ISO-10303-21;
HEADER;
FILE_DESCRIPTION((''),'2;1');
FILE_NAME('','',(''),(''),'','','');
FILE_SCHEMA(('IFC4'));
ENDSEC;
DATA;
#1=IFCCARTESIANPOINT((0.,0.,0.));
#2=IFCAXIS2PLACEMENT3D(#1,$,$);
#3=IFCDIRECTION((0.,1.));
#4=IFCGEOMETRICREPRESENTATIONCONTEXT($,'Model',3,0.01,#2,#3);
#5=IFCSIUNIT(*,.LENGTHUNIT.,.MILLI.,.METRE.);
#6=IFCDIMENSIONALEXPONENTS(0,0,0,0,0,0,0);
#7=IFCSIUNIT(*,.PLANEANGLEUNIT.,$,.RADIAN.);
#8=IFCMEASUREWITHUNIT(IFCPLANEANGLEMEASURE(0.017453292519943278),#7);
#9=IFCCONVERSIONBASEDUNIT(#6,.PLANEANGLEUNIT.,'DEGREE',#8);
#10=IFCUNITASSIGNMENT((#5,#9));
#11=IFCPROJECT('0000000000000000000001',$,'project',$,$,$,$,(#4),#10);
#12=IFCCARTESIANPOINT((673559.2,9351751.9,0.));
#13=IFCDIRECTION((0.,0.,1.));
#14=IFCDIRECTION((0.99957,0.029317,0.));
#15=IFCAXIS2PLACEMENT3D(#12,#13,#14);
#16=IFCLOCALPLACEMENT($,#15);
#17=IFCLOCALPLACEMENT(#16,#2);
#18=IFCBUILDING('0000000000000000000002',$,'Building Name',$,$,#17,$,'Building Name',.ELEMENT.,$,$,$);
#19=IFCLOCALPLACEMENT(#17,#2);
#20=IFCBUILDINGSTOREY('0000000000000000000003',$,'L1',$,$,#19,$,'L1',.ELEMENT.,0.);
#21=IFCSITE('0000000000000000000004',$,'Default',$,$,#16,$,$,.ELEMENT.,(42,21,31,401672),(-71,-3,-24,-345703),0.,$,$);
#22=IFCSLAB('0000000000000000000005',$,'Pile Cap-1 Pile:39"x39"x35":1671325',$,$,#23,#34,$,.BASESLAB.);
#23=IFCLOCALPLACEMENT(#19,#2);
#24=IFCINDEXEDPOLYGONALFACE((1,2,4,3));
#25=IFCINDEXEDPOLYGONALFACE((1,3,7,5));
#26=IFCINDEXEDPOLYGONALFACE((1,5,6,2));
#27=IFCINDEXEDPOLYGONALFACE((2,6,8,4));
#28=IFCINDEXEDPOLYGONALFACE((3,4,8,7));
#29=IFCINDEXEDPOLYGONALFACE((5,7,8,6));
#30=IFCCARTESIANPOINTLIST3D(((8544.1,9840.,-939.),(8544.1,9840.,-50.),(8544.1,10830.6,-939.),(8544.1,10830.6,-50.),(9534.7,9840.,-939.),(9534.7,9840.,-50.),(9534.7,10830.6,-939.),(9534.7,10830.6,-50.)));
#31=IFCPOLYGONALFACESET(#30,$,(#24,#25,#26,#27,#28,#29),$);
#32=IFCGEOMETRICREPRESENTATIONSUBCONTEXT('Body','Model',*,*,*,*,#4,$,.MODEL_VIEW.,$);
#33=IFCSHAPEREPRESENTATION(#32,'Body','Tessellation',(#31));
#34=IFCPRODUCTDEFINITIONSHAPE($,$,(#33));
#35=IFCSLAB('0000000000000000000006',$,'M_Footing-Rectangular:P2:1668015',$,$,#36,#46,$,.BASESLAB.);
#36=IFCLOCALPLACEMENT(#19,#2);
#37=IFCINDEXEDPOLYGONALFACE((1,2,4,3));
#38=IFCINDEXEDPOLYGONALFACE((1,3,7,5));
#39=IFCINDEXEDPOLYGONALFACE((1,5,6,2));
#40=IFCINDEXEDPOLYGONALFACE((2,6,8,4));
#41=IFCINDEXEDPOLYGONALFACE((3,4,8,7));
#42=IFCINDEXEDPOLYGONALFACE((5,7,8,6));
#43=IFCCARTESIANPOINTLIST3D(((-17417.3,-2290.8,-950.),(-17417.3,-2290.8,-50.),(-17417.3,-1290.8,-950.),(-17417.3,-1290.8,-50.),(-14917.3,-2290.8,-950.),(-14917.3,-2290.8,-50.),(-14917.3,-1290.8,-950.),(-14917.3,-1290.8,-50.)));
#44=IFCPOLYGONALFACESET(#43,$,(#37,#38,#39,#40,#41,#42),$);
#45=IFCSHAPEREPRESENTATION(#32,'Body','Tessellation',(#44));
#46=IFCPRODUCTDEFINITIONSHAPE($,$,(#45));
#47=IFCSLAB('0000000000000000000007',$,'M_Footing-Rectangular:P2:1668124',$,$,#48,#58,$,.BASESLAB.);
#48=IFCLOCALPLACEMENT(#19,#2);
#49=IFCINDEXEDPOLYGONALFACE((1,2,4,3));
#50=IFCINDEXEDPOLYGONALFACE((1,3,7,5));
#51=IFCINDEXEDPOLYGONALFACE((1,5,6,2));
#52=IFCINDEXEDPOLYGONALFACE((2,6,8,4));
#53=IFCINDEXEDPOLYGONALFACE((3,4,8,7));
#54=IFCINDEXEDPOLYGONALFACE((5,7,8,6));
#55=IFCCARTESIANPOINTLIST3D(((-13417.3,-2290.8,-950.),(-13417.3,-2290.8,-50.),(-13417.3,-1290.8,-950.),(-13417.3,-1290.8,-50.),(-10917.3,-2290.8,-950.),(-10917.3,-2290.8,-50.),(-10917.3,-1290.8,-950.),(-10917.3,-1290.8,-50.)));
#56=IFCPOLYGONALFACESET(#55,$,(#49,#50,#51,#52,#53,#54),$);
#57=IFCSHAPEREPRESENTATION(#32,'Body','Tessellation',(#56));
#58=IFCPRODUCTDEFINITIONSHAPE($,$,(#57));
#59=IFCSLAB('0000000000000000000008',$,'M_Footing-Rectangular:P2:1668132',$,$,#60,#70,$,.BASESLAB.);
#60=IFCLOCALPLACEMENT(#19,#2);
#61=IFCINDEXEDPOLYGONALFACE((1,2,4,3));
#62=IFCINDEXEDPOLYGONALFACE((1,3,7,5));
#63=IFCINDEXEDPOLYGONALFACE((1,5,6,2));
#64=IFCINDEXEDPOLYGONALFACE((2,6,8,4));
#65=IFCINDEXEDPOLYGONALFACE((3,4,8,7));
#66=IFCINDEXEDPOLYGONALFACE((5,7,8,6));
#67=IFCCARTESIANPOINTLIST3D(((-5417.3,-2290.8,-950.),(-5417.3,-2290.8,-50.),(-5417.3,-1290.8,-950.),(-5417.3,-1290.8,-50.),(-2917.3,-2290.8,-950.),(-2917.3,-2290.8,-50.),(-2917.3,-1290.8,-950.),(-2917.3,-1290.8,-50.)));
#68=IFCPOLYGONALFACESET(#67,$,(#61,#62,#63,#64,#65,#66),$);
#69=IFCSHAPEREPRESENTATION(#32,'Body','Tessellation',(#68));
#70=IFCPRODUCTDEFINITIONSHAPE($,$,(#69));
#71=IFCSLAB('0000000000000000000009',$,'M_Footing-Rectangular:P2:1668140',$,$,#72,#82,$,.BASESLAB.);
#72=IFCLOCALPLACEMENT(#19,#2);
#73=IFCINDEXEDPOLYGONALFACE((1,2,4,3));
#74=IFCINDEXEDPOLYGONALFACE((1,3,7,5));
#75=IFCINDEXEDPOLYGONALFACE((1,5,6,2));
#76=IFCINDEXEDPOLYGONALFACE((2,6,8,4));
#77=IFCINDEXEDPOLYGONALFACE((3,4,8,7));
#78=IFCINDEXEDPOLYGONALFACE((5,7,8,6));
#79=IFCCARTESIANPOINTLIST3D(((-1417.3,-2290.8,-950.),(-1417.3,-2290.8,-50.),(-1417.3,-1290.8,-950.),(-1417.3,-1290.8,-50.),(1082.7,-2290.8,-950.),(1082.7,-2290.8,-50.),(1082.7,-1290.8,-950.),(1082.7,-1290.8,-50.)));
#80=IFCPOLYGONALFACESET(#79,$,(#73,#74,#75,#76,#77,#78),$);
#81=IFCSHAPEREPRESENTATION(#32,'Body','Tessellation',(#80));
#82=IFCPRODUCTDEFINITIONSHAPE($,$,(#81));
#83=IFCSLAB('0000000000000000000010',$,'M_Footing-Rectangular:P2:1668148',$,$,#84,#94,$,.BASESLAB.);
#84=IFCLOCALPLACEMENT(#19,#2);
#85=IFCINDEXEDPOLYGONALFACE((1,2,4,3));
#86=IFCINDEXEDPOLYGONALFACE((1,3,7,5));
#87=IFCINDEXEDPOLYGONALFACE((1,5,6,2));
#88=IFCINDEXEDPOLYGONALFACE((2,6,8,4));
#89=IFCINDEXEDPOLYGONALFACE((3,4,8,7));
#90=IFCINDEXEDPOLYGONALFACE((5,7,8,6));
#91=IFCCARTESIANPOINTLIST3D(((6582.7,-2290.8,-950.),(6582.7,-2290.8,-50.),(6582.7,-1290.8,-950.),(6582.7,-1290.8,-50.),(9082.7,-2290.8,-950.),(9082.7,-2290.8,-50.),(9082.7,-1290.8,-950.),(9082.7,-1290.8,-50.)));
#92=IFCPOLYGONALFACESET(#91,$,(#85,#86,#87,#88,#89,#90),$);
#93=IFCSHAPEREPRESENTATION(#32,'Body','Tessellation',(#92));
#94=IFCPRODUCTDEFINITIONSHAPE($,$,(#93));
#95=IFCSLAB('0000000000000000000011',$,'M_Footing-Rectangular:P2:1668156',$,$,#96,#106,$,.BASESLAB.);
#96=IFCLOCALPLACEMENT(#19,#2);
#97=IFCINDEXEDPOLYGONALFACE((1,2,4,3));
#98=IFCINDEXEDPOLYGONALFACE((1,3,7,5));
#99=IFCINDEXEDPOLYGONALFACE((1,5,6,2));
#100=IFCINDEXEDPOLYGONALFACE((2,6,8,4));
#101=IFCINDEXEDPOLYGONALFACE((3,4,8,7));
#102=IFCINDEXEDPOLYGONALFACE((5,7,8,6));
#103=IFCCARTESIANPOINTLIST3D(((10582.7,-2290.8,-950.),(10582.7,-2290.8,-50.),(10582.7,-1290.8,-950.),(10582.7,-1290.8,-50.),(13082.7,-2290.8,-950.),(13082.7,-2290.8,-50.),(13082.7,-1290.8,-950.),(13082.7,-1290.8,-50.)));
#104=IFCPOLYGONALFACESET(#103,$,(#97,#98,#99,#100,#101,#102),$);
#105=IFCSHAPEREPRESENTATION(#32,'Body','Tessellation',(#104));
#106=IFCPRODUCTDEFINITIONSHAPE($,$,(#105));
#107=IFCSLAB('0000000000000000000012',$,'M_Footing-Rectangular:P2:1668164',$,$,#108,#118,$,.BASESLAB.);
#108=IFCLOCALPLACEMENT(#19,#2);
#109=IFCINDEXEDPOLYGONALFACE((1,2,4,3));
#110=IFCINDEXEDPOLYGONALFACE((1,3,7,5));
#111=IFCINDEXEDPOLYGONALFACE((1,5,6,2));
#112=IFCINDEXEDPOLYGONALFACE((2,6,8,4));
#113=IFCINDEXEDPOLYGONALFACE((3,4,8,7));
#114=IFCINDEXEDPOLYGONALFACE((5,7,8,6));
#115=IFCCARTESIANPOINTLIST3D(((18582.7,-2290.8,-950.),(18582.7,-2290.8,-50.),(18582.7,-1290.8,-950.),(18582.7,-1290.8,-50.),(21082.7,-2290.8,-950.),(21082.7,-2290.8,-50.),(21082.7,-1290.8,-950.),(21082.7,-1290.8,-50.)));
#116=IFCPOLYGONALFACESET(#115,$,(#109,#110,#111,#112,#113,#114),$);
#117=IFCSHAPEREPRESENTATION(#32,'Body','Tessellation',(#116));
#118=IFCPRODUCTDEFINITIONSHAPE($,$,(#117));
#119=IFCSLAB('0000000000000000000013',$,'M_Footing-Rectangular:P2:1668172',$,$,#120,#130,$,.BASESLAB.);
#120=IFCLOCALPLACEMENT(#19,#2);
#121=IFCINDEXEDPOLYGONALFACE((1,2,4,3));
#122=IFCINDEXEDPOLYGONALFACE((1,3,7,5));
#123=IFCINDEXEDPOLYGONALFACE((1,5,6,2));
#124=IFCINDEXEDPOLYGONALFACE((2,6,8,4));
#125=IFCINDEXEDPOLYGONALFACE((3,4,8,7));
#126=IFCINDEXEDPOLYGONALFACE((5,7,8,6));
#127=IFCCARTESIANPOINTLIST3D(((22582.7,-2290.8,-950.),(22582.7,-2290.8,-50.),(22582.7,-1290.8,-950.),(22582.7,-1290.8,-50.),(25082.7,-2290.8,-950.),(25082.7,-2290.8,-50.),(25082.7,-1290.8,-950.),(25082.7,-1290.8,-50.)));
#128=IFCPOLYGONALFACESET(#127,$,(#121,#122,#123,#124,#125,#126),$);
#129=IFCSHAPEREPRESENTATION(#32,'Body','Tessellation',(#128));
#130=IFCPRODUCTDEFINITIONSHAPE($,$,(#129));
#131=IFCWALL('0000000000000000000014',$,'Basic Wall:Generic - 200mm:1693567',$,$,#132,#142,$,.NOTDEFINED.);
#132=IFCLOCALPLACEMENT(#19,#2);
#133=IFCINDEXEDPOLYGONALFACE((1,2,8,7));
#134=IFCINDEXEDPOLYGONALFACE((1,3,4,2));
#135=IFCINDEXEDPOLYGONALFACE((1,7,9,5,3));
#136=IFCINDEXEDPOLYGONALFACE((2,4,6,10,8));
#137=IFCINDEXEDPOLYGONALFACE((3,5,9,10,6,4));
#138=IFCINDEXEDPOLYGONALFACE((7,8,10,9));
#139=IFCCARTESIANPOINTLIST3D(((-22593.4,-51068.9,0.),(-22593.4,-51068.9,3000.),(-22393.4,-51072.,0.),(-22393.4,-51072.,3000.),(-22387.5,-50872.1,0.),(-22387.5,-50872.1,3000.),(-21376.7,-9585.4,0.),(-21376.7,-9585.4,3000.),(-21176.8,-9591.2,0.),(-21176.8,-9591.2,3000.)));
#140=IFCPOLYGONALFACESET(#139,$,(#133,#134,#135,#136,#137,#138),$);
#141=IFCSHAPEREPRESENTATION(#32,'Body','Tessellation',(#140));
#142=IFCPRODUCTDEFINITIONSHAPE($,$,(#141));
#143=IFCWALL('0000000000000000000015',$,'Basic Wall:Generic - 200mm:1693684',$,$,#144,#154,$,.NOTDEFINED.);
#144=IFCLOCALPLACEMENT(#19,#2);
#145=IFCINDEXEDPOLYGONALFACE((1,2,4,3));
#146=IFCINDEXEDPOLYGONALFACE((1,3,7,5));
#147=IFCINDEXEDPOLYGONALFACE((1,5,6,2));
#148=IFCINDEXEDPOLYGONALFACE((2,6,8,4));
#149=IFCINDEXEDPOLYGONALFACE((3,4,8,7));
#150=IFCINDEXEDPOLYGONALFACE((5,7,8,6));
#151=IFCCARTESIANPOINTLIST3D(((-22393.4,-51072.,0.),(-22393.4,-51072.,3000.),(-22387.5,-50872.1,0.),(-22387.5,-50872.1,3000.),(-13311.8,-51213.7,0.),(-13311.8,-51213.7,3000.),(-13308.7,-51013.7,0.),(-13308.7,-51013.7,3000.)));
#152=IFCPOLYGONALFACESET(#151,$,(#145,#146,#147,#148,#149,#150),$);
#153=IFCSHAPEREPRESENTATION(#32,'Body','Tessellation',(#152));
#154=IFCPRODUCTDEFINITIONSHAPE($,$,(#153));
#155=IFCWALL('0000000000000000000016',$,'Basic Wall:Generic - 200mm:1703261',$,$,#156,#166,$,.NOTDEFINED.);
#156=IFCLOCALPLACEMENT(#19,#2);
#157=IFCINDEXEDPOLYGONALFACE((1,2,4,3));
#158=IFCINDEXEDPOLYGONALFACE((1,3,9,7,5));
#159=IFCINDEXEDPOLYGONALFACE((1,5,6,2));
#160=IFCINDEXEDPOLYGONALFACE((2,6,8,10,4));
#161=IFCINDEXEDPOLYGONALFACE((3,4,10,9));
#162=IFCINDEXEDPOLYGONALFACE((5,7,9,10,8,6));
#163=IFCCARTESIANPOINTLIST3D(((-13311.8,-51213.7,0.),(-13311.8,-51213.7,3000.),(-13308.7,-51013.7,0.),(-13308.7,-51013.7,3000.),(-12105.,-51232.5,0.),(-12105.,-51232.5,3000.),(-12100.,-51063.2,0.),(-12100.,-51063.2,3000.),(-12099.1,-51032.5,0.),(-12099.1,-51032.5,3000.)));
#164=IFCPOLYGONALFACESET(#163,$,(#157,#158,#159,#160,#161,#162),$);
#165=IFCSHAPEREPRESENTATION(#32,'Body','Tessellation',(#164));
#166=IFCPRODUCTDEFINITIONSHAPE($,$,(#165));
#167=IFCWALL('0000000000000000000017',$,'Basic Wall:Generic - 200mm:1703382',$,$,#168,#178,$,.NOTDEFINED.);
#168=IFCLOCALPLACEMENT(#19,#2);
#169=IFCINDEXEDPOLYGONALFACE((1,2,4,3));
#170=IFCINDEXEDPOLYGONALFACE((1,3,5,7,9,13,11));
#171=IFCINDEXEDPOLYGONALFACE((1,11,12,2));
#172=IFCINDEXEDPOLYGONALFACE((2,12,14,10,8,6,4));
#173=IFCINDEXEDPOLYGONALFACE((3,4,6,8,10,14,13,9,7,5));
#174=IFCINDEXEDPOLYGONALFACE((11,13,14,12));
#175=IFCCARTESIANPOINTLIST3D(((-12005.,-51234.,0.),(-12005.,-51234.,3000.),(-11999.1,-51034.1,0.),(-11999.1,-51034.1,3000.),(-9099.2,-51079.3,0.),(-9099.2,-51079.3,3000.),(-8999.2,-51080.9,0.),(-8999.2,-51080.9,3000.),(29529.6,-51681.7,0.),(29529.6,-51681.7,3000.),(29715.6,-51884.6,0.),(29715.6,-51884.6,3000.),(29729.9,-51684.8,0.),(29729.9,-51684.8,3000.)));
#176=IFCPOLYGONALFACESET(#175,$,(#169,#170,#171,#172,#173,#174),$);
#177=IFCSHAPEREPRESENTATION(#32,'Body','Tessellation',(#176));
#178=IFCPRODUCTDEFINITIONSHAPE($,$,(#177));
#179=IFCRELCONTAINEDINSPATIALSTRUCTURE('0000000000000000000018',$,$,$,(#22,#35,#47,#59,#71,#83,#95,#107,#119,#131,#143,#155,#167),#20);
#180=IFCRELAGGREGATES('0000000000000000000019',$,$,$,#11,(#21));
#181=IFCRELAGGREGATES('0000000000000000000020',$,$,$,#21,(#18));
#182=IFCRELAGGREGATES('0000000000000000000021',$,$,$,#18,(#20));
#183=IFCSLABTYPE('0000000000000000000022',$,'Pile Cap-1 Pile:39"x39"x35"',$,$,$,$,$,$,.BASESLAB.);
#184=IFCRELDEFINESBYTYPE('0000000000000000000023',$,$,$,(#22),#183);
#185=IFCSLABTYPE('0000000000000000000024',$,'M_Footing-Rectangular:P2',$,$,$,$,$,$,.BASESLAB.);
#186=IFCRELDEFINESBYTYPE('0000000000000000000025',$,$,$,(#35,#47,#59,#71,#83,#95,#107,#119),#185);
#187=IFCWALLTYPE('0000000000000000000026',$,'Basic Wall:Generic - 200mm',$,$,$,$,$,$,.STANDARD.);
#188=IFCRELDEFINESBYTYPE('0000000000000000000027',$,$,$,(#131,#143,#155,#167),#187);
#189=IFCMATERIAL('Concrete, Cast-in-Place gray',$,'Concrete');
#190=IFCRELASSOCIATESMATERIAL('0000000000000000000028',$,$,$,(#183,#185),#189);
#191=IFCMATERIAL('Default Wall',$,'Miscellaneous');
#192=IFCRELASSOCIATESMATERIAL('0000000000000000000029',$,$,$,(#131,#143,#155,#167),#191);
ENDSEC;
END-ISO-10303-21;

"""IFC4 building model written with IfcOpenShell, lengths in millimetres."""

from ifc_helpers import new_model, entity, si_unit, converted_unit, direction, frame, origin, place, context, subcontext, project, spatial, indexed_curve, outline, extrude, material, type_object, element, save


model = new_model("IFC4")

# Units and contexts
model_context = context("Model", 3, precision=0.01, world=origin(), true_north=direction((0.0, 1.0)))
body_context = subcontext(model_context, "Body", "Model", "MODEL_VIEW")
ifc_project = project(units=[si_unit("LENGTHUNIT", "METRE", prefix="MILLI"), converted_unit("PLANEANGLEUNIT", "DEGREE", entity("IfcPlaneAngleMeasure", 0.017453292519943278), si_unit("PLANEANGLEUNIT", "RADIAN"), dimensions=[0, 0, 0, 0, 0, 0, 0])], contexts=[model_context])

# Site, building, storey
site_placement = place(None, frame((673559.2, 9351751.9, 0.0), z_axis=(0.0, 0.0, 1.0), x_axis=(0.99957, 0.029317, 0.0)))
site = spatial("IfcSite", under=ifc_project, at=site_placement, Name="Default", CompositionType="ELEMENT", RefLatitude=(42, 21, 31, 401672), RefLongitude=(-71, -3, -24, -345703), RefElevation=0.0)
building_placement = place(site_placement, origin())
building = spatial("IfcBuilding", under=site, at=building_placement, Name="Building Name", LongName="Building Name", CompositionType="ELEMENT")
storey_placement = place(building_placement, origin())
storey = spatial("IfcBuildingStorey", under=building, at=storey_placement, Name="L1", LongName="L1", CompositionType="ELEMENT", Elevation=0.0)

# Shared definitions
ifc_material_1 = material(Name="Concrete, Cast-in-Place gray", Category="Concrete")

# Slabs
slab_type_1 = type_object("IfcSlabType", Name="Pile Cap-1 Pile:39\"x39\"x35\"", PredefinedType="BASESLAB", material=ifc_material_1)
slab_1_placement = place(storey_placement, origin())
element("IfcSlab", 1, at=slab_1_placement, inside=storey, type_object=slab_type_1, Name="Pile Cap-1 Pile:39\"x39\"x35\":1671325", PredefinedType="BASESLAB", context=body_context, shape_type="SweptSolid", body=[
    extrude(outline(indexed_curve([(-495.3, -495.3), (495.3, -495.3), (495.3, 495.3), (-495.3, 495.3), (-495.3, -495.3)], self_intersect=False)), frame((9039.4, 10335.3, -939.0)), (0.0, 0.0, 1.0), 889.0),
])
slab_type_2 = type_object("IfcSlabType", Name="M_Footing-Rectangular:P2", PredefinedType="BASESLAB", material=ifc_material_1)
slab_2_placement = place(storey_placement, origin())
element("IfcSlab", 2, at=slab_2_placement, inside=storey, type_object=slab_type_2, Name="M_Footing-Rectangular:P2:1668015", PredefinedType="BASESLAB", context=body_context, shape_type="SweptSolid", body=[
    extrude(outline(indexed_curve([(-500.0, -1250.0), (500.0, -1250.0), (500.0, 1250.0), (-500.0, 1250.0), (-500.0, -1250.0)], self_intersect=False)), frame((-16167.3, -1790.8, -950.0), z_axis=(0.0, 0.0, 1.0), x_axis=(0.0, -1.0, 0.0)), (0.0, 0.0, 1.0), 900.0),
])
slab_3_placement = place(storey_placement, origin())
element("IfcSlab", 3, at=slab_3_placement, inside=storey, type_object=slab_type_2, Name="M_Footing-Rectangular:P2:1668124", PredefinedType="BASESLAB", context=body_context, shape_type="SweptSolid", body=[
    extrude(outline(indexed_curve([(-500.0, -1250.0), (500.0, -1250.0), (500.0, 1250.0), (-500.0, 1250.0), (-500.0, -1250.0)], self_intersect=False)), frame((-12167.3, -1790.8, -950.0), z_axis=(0.0, 0.0, 1.0), x_axis=(0.0, -1.0, 0.0)), (0.0, 0.0, 1.0), 900.0),
])
slab_4_placement = place(storey_placement, origin())
element("IfcSlab", 4, at=slab_4_placement, inside=storey, type_object=slab_type_2, Name="M_Footing-Rectangular:P2:1668132", PredefinedType="BASESLAB", context=body_context, shape_type="SweptSolid", body=[
    extrude(outline(indexed_curve([(-500.0, -1250.0), (500.0, -1250.0), (500.0, 1250.0), (-500.0, 1250.0), (-500.0, -1250.0)], self_intersect=False)), frame((-4167.3, -1790.8, -950.0), z_axis=(0.0, 0.0, 1.0), x_axis=(0.0, -1.0, 0.0)), (0.0, 0.0, 1.0), 900.0),
])
slab_5_placement = place(storey_placement, origin())
element("IfcSlab", 5, at=slab_5_placement, inside=storey, type_object=slab_type_2, Name="M_Footing-Rectangular:P2:1668140", PredefinedType="BASESLAB", context=body_context, shape_type="SweptSolid", body=[
    extrude(outline(indexed_curve([(-500.0, -1250.0), (500.0, -1250.0), (500.0, 1250.0), (-500.0, 1250.0), (-500.0, -1250.0)], self_intersect=False)), frame((-167.3, -1790.8, -950.0), z_axis=(0.0, 0.0, 1.0), x_axis=(0.0, -1.0, 0.0)), (0.0, 0.0, 1.0), 900.0),
])
slab_6_placement = place(storey_placement, origin())
element("IfcSlab", 6, at=slab_6_placement, inside=storey, type_object=slab_type_2, Name="M_Footing-Rectangular:P2:1668148", PredefinedType="BASESLAB", context=body_context, shape_type="SweptSolid", body=[
    extrude(outline(indexed_curve([(-500.0, -1250.0), (500.0, -1250.0), (500.0, 1250.0), (-500.0, 1250.0), (-500.0, -1250.0)], self_intersect=False)), frame((7832.7, -1790.8, -950.0), z_axis=(0.0, 0.0, 1.0), x_axis=(0.0, -1.0, 0.0)), (0.0, 0.0, 1.0), 900.0),
])
slab_7_placement = place(storey_placement, origin())
element("IfcSlab", 7, at=slab_7_placement, inside=storey, type_object=slab_type_2, Name="M_Footing-Rectangular:P2:1668156", PredefinedType="BASESLAB", context=body_context, shape_type="SweptSolid", body=[
    extrude(outline(indexed_curve([(-500.0, -1250.0), (500.0, -1250.0), (500.0, 1250.0), (-500.0, 1250.0), (-500.0, -1250.0)], self_intersect=False)), frame((11832.7, -1790.8, -950.0), z_axis=(0.0, 0.0, 1.0), x_axis=(0.0, -1.0, 0.0)), (0.0, 0.0, 1.0), 900.0),
])
slab_8_placement = place(storey_placement, origin())
element("IfcSlab", 8, at=slab_8_placement, inside=storey, type_object=slab_type_2, Name="M_Footing-Rectangular:P2:1668164", PredefinedType="BASESLAB", context=body_context, shape_type="SweptSolid", body=[
    extrude(outline(indexed_curve([(-500.0, -1250.0), (500.0, -1250.0), (500.0, 1250.0), (-500.0, 1250.0), (-500.0, -1250.0)], self_intersect=False)), frame((19832.7, -1790.8, -950.0), z_axis=(0.0, 0.0, 1.0), x_axis=(0.0, -1.0, 0.0)), (0.0, 0.0, 1.0), 900.0),
])
slab_9_placement = place(storey_placement, origin())
element("IfcSlab", 9, at=slab_9_placement, inside=storey, type_object=slab_type_2, Name="M_Footing-Rectangular:P2:1668172", PredefinedType="BASESLAB", context=body_context, shape_type="SweptSolid", body=[
    extrude(outline(indexed_curve([(-500.0, -1250.0), (500.0, -1250.0), (500.0, 1250.0), (-500.0, 1250.0), (-500.0, -1250.0)], self_intersect=False)), frame((23832.7, -1790.8, -950.0), z_axis=(0.0, 0.0, 1.0), x_axis=(0.0, -1.0, 0.0)), (0.0, 0.0, 1.0), 900.0),
])

# Walls
ifc_material_2 = material(Name="Default Wall", Category="Miscellaneous")
wall_type_1 = type_object("IfcWallType", Name="Basic Wall:Generic - 200mm", PredefinedType="STANDARD")
wall_1_placement = place(storey_placement, frame((-21276.7, -9588.3, 0.0), z_axis=(0.0, 0.0, 1.0), x_axis=(-0.029317, -0.99957, 0.0)))
element("IfcWall", 10, at=wall_1_placement, inside=storey, type_object=wall_type_1, material=ifc_material_2, Name="Basic Wall:Generic - 200mm:1693567", PredefinedType="NOTDEFINED", context=body_context, shape_type="SweptSolid", body=[
    extrude(outline(indexed_curve([(41501.4, -100.0), (41498.6, 100.0), (41298.6, 100.0), (0.0, 100.0), (0.0, -100.0), (41501.4, -100.0)], self_intersect=False)), origin(), (0.0, 0.0, 1.0), 3000.0),
])
wall_2_placement = place(storey_placement, frame((-22391.9, -50972.1, 0.0), z_axis=(0.0, 0.0, 1.0), x_axis=(0.999878, -0.015591, 0.0)))
element("IfcWall", 11, at=wall_2_placement, inside=storey, type_object=wall_type_1, material=ifc_material_2, Name="Basic Wall:Generic - 200mm:1693684", PredefinedType="NOTDEFINED", context=body_context, shape_type="SweptSolid", body=[
    extrude(outline(indexed_curve([(9082.7, -100.0), (9082.7, 100.0), (2.7, 100.0), (0.0, -100.0), (9082.7, -100.0)], self_intersect=False)), origin(), (0.0, 0.0, 1.0), 3000.0),
])
wall_3_placement = place(storey_placement, frame((-13310.2, -51113.7, 0.0), z_axis=(0.0, 0.0, 1.0), x_axis=(0.999878, -0.015591, 0.0)))
element("IfcWall", 12, at=wall_3_placement, inside=storey, type_object=wall_type_1, material=ifc_material_2, Name="Basic Wall:Generic - 200mm:1703261", PredefinedType="NOTDEFINED", context=body_context, shape_type="SweptSolid", body=[
    extrude(outline(indexed_curve([(1206.9, -100.0), (1209.2, 69.4), (1209.7, 100.0), (0.0, 100.0), (0.0, -100.0), (1206.9, -100.0)], self_intersect=False)), origin(), (0.0, 0.0, 1.0), 3000.0),
])
wall_4_placement = place(storey_placement, frame((-12003.4, -51134.0, 0.0), z_axis=(0.0, 0.0, 1.0), x_axis=(0.999878, -0.015591, 0.0)))
element("IfcWall", 13, at=wall_4_placement, inside=storey, type_object=wall_type_1, material=ifc_material_2, Name="Basic Wall:Generic - 200mm:1703382", PredefinedType="NOTDEFINED", context=body_context, shape_type="SweptSolid", body=[
    extrude(outline(indexed_curve([(41725.7, -100.0), (41736.9, 100.0), (41536.6, 100.0), (3003.0, 100.0), (2903.0, 100.0), (2.7, 100.0), (0.0, -100.0), (41725.7, -100.0)], self_intersect=False)), origin(), (0.0, 0.0, 1.0), 3000.0),
])

save(model, "model.ifc")
